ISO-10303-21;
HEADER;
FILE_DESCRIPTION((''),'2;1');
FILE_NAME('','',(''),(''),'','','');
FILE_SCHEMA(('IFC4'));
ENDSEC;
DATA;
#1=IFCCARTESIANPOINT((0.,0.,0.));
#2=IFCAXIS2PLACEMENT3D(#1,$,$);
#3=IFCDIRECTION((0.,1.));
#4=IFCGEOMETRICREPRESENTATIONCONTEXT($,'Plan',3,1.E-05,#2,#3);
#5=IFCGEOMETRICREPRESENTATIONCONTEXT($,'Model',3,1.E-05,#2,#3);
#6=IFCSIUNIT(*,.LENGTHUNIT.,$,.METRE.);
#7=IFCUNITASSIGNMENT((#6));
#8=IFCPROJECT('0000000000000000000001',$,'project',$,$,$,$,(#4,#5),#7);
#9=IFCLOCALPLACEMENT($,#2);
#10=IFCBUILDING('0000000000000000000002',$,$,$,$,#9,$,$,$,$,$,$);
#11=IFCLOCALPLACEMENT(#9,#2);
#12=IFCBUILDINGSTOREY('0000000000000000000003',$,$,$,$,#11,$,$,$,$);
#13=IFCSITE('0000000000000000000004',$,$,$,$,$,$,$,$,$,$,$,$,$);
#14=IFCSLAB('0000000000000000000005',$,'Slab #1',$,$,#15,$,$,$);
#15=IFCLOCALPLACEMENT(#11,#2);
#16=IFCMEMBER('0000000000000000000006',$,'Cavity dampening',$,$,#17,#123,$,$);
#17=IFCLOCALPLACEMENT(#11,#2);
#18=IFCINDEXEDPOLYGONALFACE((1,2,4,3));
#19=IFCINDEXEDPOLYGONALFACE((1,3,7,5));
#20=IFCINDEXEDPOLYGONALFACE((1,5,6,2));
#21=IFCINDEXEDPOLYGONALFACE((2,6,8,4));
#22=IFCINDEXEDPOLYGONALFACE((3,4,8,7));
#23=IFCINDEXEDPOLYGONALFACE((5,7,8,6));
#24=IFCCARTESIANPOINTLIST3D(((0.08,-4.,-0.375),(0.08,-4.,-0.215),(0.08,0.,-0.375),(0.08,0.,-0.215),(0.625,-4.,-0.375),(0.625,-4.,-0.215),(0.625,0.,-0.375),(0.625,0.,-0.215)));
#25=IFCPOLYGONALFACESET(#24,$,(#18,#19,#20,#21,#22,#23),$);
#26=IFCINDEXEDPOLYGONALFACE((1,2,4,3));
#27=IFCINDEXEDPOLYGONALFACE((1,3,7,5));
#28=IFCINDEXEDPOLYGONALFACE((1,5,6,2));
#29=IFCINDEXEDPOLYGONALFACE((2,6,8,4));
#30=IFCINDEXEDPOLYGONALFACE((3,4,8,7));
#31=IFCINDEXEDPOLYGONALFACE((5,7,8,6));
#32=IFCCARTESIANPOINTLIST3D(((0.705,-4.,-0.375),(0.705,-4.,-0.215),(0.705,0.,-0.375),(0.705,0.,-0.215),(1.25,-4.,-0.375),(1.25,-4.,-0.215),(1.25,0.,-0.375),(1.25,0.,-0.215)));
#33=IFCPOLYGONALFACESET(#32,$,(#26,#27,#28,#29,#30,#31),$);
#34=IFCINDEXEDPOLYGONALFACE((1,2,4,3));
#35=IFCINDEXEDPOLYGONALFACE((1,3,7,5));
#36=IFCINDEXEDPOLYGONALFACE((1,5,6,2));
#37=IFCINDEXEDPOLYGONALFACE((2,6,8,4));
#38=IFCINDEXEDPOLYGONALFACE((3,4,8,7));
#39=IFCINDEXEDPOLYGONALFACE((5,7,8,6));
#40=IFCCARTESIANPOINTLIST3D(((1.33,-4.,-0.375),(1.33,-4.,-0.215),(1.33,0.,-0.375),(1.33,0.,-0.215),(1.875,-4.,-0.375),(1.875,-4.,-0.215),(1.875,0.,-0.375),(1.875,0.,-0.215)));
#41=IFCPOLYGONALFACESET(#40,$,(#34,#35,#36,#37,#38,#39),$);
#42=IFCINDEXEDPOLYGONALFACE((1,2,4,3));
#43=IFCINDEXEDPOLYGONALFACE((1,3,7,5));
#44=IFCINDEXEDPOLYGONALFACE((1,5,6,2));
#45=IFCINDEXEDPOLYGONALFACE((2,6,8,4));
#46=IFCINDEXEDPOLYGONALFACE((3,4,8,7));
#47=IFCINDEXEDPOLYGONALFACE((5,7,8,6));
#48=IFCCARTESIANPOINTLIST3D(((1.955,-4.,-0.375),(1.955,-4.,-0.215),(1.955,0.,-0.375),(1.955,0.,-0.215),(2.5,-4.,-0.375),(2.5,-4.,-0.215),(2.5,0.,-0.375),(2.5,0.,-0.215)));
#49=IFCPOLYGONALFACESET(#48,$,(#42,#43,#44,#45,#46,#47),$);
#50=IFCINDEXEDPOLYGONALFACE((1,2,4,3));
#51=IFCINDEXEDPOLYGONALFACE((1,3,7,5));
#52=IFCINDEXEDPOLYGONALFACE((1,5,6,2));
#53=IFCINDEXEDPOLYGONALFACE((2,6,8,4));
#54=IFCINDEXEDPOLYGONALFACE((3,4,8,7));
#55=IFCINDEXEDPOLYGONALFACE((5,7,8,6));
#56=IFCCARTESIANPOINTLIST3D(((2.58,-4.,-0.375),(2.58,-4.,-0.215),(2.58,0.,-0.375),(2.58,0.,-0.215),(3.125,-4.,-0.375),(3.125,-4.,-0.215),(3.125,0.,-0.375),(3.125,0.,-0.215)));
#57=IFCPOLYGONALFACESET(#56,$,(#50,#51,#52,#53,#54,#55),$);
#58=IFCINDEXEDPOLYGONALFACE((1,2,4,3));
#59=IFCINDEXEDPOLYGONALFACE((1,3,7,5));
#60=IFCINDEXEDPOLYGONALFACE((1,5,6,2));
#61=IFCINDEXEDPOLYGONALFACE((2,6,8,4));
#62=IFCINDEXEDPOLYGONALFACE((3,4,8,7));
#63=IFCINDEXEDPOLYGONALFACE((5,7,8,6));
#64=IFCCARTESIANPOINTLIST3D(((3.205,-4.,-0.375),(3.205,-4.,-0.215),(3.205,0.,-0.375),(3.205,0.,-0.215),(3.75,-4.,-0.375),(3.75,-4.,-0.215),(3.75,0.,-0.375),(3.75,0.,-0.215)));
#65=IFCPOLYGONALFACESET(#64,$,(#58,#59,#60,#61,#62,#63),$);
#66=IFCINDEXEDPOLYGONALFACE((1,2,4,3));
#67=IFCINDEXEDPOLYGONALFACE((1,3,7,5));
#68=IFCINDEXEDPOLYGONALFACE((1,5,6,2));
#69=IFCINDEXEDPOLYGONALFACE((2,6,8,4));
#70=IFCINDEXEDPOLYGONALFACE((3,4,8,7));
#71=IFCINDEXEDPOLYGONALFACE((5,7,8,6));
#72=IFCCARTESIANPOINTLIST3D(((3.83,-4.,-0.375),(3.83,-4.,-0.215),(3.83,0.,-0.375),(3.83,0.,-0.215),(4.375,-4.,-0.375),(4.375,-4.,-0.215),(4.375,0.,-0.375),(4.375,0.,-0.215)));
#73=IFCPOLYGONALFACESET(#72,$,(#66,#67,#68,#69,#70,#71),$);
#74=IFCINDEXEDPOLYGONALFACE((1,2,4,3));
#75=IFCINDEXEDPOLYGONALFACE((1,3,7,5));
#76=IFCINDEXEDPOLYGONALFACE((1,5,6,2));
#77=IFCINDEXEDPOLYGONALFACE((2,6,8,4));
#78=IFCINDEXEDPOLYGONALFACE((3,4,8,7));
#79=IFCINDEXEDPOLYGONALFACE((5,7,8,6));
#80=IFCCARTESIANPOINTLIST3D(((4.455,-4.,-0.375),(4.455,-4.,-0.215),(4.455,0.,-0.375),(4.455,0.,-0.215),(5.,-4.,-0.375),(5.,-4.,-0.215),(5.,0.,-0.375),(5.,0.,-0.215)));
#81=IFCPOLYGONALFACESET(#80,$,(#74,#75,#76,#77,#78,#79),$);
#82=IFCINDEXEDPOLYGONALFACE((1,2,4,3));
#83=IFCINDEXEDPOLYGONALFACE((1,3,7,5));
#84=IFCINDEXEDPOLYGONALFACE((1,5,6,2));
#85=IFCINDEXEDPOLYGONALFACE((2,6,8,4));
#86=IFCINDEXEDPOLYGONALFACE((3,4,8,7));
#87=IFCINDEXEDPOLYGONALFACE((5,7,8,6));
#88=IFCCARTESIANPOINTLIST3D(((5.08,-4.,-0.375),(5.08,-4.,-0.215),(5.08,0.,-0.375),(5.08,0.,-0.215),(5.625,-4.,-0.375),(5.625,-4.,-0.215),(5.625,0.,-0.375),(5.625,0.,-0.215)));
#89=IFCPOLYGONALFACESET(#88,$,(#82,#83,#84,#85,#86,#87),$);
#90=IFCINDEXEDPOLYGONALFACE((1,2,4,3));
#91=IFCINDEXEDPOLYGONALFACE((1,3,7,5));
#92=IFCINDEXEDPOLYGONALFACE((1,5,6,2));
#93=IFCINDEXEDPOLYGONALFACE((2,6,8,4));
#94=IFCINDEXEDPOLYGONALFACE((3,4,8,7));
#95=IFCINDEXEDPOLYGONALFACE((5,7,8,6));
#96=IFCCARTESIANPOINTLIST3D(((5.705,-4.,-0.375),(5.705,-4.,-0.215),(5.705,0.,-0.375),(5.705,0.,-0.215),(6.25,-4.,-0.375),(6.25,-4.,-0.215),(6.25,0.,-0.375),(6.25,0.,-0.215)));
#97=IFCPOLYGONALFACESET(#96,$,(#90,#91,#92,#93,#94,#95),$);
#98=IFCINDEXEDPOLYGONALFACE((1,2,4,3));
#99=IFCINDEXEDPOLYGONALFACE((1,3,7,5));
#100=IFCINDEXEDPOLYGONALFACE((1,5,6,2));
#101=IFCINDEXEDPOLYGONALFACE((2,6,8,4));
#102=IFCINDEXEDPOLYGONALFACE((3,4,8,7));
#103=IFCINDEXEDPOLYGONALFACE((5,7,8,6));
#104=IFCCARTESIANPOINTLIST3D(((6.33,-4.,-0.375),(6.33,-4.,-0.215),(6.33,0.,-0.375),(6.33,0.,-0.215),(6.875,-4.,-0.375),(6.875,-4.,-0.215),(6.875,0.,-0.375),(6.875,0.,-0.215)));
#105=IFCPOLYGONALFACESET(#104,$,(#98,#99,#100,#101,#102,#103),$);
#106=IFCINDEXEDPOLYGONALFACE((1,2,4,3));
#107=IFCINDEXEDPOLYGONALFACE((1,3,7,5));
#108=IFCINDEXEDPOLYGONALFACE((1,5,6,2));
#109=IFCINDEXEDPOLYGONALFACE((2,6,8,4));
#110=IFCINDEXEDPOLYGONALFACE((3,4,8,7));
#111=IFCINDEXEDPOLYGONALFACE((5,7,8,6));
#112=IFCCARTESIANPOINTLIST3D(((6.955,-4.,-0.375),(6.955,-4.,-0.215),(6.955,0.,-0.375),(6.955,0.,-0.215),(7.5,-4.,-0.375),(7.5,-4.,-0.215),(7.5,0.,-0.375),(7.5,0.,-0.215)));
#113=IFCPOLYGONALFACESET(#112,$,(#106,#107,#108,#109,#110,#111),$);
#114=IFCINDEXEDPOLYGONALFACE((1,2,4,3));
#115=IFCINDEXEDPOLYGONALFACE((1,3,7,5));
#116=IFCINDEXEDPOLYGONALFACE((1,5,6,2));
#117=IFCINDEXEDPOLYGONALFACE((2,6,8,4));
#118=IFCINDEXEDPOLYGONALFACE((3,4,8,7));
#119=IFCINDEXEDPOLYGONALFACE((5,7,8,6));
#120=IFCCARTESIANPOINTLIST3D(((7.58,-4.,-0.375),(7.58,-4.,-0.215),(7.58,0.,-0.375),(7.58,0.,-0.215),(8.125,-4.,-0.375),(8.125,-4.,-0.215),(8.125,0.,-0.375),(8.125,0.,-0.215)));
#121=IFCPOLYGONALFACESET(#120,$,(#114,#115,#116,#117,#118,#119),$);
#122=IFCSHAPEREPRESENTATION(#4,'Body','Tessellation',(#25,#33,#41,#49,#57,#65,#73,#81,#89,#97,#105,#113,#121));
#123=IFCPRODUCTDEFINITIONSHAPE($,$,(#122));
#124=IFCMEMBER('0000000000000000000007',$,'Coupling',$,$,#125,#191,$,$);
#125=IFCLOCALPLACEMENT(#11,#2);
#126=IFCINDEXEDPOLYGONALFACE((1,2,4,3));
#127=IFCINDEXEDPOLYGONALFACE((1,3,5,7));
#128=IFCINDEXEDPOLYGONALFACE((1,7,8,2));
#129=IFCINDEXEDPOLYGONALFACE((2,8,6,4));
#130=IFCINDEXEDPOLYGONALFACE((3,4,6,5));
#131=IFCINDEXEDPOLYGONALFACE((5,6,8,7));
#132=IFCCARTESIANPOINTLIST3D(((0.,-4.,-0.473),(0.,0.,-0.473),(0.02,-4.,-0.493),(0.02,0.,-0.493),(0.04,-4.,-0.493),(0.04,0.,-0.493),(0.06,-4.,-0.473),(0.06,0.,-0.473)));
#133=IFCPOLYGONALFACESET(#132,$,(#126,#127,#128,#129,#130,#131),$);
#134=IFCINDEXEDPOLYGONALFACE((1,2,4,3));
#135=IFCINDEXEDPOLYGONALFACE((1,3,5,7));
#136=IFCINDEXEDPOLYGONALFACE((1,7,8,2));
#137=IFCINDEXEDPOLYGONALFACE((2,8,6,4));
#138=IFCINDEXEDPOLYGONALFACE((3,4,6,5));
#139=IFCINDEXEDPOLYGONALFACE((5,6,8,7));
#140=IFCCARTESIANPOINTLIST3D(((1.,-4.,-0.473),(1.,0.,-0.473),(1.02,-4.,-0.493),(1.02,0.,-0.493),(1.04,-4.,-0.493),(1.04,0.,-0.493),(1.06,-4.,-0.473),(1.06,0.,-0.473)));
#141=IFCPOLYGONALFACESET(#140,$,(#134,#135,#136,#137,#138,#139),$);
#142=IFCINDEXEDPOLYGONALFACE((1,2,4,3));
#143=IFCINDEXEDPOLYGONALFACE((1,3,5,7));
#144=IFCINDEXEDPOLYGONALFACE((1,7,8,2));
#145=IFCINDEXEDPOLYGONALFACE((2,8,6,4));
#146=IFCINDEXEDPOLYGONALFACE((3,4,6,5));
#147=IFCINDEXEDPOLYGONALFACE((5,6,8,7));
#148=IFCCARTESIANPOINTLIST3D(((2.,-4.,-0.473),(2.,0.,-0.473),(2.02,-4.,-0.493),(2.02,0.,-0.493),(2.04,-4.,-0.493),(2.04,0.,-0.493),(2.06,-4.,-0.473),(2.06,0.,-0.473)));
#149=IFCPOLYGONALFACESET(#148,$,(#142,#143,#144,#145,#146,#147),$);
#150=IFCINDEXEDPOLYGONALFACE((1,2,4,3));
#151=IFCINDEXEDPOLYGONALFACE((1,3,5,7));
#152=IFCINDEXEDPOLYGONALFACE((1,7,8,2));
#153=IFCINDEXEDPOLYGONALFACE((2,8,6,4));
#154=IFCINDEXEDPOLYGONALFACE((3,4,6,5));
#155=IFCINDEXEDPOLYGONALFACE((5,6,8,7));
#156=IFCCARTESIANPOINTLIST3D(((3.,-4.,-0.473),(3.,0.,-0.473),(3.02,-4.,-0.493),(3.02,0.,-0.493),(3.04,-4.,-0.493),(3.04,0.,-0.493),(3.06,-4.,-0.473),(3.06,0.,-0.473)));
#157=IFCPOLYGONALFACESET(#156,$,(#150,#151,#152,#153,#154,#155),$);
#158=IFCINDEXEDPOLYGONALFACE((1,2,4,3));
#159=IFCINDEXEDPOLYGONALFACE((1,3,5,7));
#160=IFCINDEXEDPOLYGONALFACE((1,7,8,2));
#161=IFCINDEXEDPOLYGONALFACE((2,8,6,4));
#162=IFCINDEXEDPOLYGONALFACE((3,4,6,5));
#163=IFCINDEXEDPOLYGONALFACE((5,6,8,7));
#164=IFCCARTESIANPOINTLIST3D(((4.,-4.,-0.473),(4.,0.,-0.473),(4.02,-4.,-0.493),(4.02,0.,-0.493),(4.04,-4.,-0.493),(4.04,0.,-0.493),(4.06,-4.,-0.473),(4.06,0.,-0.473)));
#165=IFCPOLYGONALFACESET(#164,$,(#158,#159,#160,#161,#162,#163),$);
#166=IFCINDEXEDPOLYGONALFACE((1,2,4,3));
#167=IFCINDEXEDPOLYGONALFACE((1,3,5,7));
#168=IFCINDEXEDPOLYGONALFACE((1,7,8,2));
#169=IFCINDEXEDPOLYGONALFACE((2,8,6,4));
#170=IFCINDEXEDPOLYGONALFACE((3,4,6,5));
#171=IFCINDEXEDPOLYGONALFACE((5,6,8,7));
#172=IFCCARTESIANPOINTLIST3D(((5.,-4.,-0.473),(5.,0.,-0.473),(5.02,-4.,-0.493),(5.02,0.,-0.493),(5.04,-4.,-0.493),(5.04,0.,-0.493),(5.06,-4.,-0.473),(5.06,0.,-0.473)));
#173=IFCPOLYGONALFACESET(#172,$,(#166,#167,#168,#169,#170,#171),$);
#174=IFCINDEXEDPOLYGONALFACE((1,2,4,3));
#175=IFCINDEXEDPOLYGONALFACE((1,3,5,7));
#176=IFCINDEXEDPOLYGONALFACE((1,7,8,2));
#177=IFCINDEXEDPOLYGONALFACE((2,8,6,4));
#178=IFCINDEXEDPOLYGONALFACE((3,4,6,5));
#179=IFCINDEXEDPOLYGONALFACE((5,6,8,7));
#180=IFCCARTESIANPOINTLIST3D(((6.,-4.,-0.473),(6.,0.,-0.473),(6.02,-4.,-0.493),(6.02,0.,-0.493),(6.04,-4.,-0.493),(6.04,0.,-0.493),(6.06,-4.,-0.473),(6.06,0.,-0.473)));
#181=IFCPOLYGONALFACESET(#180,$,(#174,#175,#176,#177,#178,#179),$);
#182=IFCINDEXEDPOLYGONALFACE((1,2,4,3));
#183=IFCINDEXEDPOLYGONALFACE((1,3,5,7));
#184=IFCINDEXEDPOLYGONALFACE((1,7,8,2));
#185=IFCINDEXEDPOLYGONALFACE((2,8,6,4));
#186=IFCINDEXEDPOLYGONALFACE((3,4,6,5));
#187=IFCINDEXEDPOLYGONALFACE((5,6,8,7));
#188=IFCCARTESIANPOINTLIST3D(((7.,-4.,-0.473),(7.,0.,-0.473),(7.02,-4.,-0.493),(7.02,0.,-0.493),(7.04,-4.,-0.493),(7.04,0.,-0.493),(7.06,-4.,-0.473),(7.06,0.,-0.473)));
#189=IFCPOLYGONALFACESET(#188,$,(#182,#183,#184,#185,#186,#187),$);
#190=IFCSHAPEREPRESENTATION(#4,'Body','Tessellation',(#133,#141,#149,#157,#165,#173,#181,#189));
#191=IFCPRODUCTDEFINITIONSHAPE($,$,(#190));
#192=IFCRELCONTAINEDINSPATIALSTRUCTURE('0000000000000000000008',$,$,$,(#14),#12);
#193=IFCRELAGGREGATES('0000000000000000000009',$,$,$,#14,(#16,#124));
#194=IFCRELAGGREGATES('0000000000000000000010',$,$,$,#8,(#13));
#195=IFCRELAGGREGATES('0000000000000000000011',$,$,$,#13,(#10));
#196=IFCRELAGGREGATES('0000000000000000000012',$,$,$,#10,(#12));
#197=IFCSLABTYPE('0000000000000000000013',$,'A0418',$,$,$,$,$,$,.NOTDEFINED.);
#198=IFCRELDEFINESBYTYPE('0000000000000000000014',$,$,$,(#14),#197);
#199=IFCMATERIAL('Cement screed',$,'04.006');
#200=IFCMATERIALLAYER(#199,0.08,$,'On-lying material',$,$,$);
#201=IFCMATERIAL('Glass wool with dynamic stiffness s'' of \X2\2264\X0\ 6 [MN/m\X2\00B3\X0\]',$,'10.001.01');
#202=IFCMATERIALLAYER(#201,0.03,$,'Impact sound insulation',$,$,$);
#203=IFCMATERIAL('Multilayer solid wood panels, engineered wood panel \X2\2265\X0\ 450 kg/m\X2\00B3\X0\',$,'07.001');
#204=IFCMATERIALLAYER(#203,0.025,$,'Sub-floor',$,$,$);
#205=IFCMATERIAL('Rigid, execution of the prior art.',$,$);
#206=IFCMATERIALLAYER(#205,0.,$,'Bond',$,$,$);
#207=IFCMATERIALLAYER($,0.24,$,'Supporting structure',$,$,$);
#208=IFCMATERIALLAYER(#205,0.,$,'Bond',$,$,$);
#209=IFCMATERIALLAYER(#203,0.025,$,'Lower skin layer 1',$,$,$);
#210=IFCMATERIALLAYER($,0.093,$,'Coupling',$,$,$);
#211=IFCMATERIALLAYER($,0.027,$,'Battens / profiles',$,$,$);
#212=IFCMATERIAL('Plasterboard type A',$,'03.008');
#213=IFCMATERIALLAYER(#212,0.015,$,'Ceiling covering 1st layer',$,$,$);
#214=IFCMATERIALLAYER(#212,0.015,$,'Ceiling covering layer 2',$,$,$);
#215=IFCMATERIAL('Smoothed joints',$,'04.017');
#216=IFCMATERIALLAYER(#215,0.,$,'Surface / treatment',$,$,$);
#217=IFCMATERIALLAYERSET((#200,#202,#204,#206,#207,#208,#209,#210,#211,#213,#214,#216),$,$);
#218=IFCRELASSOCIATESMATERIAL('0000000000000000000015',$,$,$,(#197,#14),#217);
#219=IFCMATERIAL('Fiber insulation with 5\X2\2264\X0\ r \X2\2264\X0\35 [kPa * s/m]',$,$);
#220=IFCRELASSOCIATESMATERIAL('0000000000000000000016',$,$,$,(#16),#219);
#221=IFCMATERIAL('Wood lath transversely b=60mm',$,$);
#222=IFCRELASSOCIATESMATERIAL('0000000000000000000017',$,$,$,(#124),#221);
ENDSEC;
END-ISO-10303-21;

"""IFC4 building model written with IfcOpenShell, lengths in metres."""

from ifc_helpers import new_model, si_unit, direction, frame, frame_2d, origin, place, context, project, spatial, polyline, rectangle, outline, extrude, material, layer, layer_set, type_object, element, aggregate, save


model = new_model("IFC4")

# Units and contexts
plan_context = context("Plan", 3, precision=1e-05, world=origin(), true_north=direction((0.0, 1.0)))
model_context = context("Model", 3, precision=1e-05, world=origin(), true_north=direction((0.0, 1.0)))
ifc_project = project(units=[si_unit("LENGTHUNIT", "METRE")], contexts=[plan_context, model_context])

# Site, building, storey
site = spatial("IfcSite", under=ifc_project)
building_placement = place(None, origin())
building = spatial("IfcBuilding", under=site, at=building_placement)
storey_placement = place(building_placement, origin())
storey = spatial("IfcBuildingStorey", under=building, at=storey_placement)

# Slab, members
ifc_material_1 = material(Name="Cement screed", Category="04.006")
ifc_layer_1 = layer(ifc_material_1, 0.08, Name="On-lying material")
ifc_material_2 = material(Name="Glass wool with dynamic stiffness s' of ≤ 6 [MN/m³]", Category="10.001.01")
ifc_layer_2 = layer(ifc_material_2, 0.03, Name="Impact sound insulation")
ifc_material_3 = material(Name="Multilayer solid wood panels, engineered wood panel ≥ 450 kg/m³", Category="07.001")
ifc_layer_3 = layer(ifc_material_3, 0.025, Name="Sub-floor")
ifc_material_4 = material(Name="Rigid, execution of the prior art.")
ifc_layer_4 = layer(ifc_material_4, 0.0, Name="Bond")
ifc_layer_5 = layer(None, 0.24, Name="Supporting structure")
ifc_layer_6 = layer(ifc_material_4, 0.0, Name="Bond")
ifc_layer_7 = layer(ifc_material_3, 0.025, Name="Lower skin layer 1")
ifc_layer_8 = layer(None, 0.093, Name="Coupling")
ifc_layer_9 = layer(None, 0.027, Name="Battens / profiles")
ifc_material_5 = material(Name="Plasterboard type A", Category="03.008")
ifc_layer_10 = layer(ifc_material_5, 0.015, Name="Ceiling covering 1st layer")
ifc_layer_11 = layer(ifc_material_5, 0.015, Name="Ceiling covering layer 2")
ifc_material_6 = material(Name="Smoothed joints", Category="04.017")
ifc_layer_12 = layer(ifc_material_6, 0.0, Name="Surface / treatment")
ifc_layer_set = layer_set([ifc_layer_1, ifc_layer_2, ifc_layer_3, ifc_layer_4, ifc_layer_5, ifc_layer_6, ifc_layer_7, ifc_layer_8, ifc_layer_9, ifc_layer_10, ifc_layer_11, ifc_layer_12])
slab_type = type_object("IfcSlabType", Name="A0418", PredefinedType="NOTDEFINED", material=ifc_layer_set)
slab_placement = place(None, frame((0.0, 0.0, 0.0), z_axis=(0.0, 0.0, -1.0), x_axis=(1.0, 0.0, 0.0)))
slab = element("IfcSlab", 1, at=slab_placement, inside=storey, type_object=slab_type, material=ifc_layer_set, Name="Slab #1")
ifc_material_7 = material(Name="Fiber insulation with 5≤ r ≤35 [kPa * s/m]")
member_1_placement = place(slab_placement, origin())
member_1 = element("IfcMember", 2, at=member_1_placement, material=ifc_material_7, Name="Cavity dampening", context=plan_context, shape_type="SweptSolid", body=[
    extrude(rectangle(XDim=0.545, YDim=0.16, at=frame_2d((0.2725, 0.08), x_axis=(1.0, 0.0))), frame((0.08, 4.0, 0.215), z_axis=(0.0, -1.0, 0.0), x_axis=(1.0, 0.0, 0.0)), (0.0, 0.0, 1.0), 4.0),
    extrude(rectangle(XDim=0.545, YDim=0.16, at=frame_2d((0.2725, 0.08), x_axis=(1.0, 0.0))), frame((0.705, 4.0, 0.215), z_axis=(0.0, -1.0, 0.0), x_axis=(1.0, 0.0, 0.0)), (0.0, 0.0, 1.0), 4.0),
    extrude(rectangle(XDim=0.545, YDim=0.16, at=frame_2d((0.2725, 0.08), x_axis=(1.0, 0.0))), frame((1.33, 4.0, 0.215), z_axis=(0.0, -1.0, 0.0), x_axis=(1.0, 0.0, 0.0)), (0.0, 0.0, 1.0), 4.0),
    extrude(rectangle(XDim=0.545, YDim=0.16, at=frame_2d((0.2725, 0.08), x_axis=(1.0, 0.0))), frame((1.955, 4.0, 0.215), z_axis=(0.0, -1.0, 0.0), x_axis=(1.0, 0.0, 0.0)), (0.0, 0.0, 1.0), 4.0),
    extrude(rectangle(XDim=0.545, YDim=0.16, at=frame_2d((0.2725, 0.08), x_axis=(1.0, 0.0))), frame((2.58, 4.0, 0.215), z_axis=(0.0, -1.0, 0.0), x_axis=(1.0, 0.0, 0.0)), (0.0, 0.0, 1.0), 4.0),
    extrude(rectangle(XDim=0.545, YDim=0.16, at=frame_2d((0.2725, 0.08), x_axis=(1.0, 0.0))), frame((3.205, 4.0, 0.215), z_axis=(0.0, -1.0, 0.0), x_axis=(1.0, 0.0, 0.0)), (0.0, 0.0, 1.0), 4.0),
    extrude(rectangle(XDim=0.545, YDim=0.16, at=frame_2d((0.2725, 0.08), x_axis=(1.0, 0.0))), frame((3.83, 4.0, 0.215), z_axis=(0.0, -1.0, 0.0), x_axis=(1.0, 0.0, 0.0)), (0.0, 0.0, 1.0), 4.0),
    extrude(rectangle(XDim=0.545, YDim=0.16, at=frame_2d((0.2725, 0.08), x_axis=(1.0, 0.0))), frame((4.455, 4.0, 0.215), z_axis=(0.0, -1.0, 0.0), x_axis=(1.0, 0.0, 0.0)), (0.0, 0.0, 1.0), 4.0),
    extrude(rectangle(XDim=0.545, YDim=0.16, at=frame_2d((0.2725, 0.08), x_axis=(1.0, 0.0))), frame((5.08, 4.0, 0.215), z_axis=(0.0, -1.0, 0.0), x_axis=(1.0, 0.0, 0.0)), (0.0, 0.0, 1.0), 4.0),
    extrude(rectangle(XDim=0.545, YDim=0.16, at=frame_2d((0.2725, 0.08), x_axis=(1.0, 0.0))), frame((5.705, 4.0, 0.215), z_axis=(0.0, -1.0, 0.0), x_axis=(1.0, 0.0, 0.0)), (0.0, 0.0, 1.0), 4.0),
    extrude(rectangle(XDim=0.545, YDim=0.16, at=frame_2d((0.2725, 0.08), x_axis=(1.0, 0.0))), frame((6.33, 4.0, 0.215), z_axis=(0.0, -1.0, 0.0), x_axis=(1.0, 0.0, 0.0)), (0.0, 0.0, 1.0), 4.0),
    extrude(rectangle(XDim=0.545, YDim=0.16, at=frame_2d((0.2725, 0.08), x_axis=(1.0, 0.0))), frame((6.955, 4.0, 0.215), z_axis=(0.0, -1.0, 0.0), x_axis=(1.0, 0.0, 0.0)), (0.0, 0.0, 1.0), 4.0),
    extrude(rectangle(XDim=0.545, YDim=0.16, at=frame_2d((0.2725, 0.08), x_axis=(1.0, 0.0))), frame((7.58, 4.0, 0.215), z_axis=(0.0, -1.0, 0.0), x_axis=(1.0, 0.0, 0.0)), (0.0, 0.0, 1.0), 4.0),
])
ifc_material_8 = material(Name="Wood lath transversely b=60mm")
member_2_placement = place(slab_placement, origin())
member_2 = element("IfcMember", 3, at=member_2_placement, material=ifc_material_8, Name="Coupling", context=plan_context, shape_type="SweptSolid", body=[
    extrude(outline(polyline([(0.0, 0.0), (0.06, 0.0), (0.04, 0.02), (0.02, 0.02), (0.0, 0.0)])), frame((0.0, 4.0, 0.473), z_axis=(0.0, -1.0, 0.0), x_axis=(1.0, 0.0, 0.0)), (0.0, 0.0, 1.0), 4.0),
    extrude(outline(polyline([(0.0, 0.0), (0.06, 0.0), (0.04, 0.02), (0.02, 0.02), (0.0, 0.0)])), frame((1.0, 4.0, 0.473), z_axis=(0.0, -1.0, 0.0), x_axis=(1.0, 0.0, 0.0)), (0.0, 0.0, 1.0), 4.0),
    extrude(outline(polyline([(0.0, 0.0), (0.06, 0.0), (0.04, 0.02), (0.02, 0.02), (0.0, 0.0)])), frame((2.0, 4.0, 0.473), z_axis=(0.0, -1.0, 0.0), x_axis=(1.0, 0.0, 0.0)), (0.0, 0.0, 1.0), 4.0),
    extrude(outline(polyline([(0.0, 0.0), (0.06, 0.0), (0.04, 0.02), (0.02, 0.02), (0.0, 0.0)])), frame((3.0, 4.0, 0.473), z_axis=(0.0, -1.0, 0.0), x_axis=(1.0, 0.0, 0.0)), (0.0, 0.0, 1.0), 4.0),
    extrude(outline(polyline([(0.0, 0.0), (0.06, 0.0), (0.04, 0.02), (0.02, 0.02), (0.0, 0.0)])), frame((4.0, 4.0, 0.473), z_axis=(0.0, -1.0, 0.0), x_axis=(1.0, 0.0, 0.0)), (0.0, 0.0, 1.0), 4.0),
    extrude(outline(polyline([(0.0, 0.0), (0.06, 0.0), (0.04, 0.02), (0.02, 0.02), (0.0, 0.0)])), frame((5.0, 4.0, 0.473), z_axis=(0.0, -1.0, 0.0), x_axis=(1.0, 0.0, 0.0)), (0.0, 0.0, 1.0), 4.0),
    extrude(outline(polyline([(0.0, 0.0), (0.06, 0.0), (0.04, 0.02), (0.02, 0.02), (0.0, 0.0)])), frame((6.0, 4.0, 0.473), z_axis=(0.0, -1.0, 0.0), x_axis=(1.0, 0.0, 0.0)), (0.0, 0.0, 1.0), 4.0),
    extrude(outline(polyline([(0.0, 0.0), (0.06, 0.0), (0.04, 0.02), (0.02, 0.02), (0.0, 0.0)])), frame((7.0, 4.0, 0.473), z_axis=(0.0, -1.0, 0.0), x_axis=(1.0, 0.0, 0.0)), (0.0, 0.0, 1.0), 4.0),
])
aggregate(slab, [member_1, member_2])

save(model, "model.ifc")
